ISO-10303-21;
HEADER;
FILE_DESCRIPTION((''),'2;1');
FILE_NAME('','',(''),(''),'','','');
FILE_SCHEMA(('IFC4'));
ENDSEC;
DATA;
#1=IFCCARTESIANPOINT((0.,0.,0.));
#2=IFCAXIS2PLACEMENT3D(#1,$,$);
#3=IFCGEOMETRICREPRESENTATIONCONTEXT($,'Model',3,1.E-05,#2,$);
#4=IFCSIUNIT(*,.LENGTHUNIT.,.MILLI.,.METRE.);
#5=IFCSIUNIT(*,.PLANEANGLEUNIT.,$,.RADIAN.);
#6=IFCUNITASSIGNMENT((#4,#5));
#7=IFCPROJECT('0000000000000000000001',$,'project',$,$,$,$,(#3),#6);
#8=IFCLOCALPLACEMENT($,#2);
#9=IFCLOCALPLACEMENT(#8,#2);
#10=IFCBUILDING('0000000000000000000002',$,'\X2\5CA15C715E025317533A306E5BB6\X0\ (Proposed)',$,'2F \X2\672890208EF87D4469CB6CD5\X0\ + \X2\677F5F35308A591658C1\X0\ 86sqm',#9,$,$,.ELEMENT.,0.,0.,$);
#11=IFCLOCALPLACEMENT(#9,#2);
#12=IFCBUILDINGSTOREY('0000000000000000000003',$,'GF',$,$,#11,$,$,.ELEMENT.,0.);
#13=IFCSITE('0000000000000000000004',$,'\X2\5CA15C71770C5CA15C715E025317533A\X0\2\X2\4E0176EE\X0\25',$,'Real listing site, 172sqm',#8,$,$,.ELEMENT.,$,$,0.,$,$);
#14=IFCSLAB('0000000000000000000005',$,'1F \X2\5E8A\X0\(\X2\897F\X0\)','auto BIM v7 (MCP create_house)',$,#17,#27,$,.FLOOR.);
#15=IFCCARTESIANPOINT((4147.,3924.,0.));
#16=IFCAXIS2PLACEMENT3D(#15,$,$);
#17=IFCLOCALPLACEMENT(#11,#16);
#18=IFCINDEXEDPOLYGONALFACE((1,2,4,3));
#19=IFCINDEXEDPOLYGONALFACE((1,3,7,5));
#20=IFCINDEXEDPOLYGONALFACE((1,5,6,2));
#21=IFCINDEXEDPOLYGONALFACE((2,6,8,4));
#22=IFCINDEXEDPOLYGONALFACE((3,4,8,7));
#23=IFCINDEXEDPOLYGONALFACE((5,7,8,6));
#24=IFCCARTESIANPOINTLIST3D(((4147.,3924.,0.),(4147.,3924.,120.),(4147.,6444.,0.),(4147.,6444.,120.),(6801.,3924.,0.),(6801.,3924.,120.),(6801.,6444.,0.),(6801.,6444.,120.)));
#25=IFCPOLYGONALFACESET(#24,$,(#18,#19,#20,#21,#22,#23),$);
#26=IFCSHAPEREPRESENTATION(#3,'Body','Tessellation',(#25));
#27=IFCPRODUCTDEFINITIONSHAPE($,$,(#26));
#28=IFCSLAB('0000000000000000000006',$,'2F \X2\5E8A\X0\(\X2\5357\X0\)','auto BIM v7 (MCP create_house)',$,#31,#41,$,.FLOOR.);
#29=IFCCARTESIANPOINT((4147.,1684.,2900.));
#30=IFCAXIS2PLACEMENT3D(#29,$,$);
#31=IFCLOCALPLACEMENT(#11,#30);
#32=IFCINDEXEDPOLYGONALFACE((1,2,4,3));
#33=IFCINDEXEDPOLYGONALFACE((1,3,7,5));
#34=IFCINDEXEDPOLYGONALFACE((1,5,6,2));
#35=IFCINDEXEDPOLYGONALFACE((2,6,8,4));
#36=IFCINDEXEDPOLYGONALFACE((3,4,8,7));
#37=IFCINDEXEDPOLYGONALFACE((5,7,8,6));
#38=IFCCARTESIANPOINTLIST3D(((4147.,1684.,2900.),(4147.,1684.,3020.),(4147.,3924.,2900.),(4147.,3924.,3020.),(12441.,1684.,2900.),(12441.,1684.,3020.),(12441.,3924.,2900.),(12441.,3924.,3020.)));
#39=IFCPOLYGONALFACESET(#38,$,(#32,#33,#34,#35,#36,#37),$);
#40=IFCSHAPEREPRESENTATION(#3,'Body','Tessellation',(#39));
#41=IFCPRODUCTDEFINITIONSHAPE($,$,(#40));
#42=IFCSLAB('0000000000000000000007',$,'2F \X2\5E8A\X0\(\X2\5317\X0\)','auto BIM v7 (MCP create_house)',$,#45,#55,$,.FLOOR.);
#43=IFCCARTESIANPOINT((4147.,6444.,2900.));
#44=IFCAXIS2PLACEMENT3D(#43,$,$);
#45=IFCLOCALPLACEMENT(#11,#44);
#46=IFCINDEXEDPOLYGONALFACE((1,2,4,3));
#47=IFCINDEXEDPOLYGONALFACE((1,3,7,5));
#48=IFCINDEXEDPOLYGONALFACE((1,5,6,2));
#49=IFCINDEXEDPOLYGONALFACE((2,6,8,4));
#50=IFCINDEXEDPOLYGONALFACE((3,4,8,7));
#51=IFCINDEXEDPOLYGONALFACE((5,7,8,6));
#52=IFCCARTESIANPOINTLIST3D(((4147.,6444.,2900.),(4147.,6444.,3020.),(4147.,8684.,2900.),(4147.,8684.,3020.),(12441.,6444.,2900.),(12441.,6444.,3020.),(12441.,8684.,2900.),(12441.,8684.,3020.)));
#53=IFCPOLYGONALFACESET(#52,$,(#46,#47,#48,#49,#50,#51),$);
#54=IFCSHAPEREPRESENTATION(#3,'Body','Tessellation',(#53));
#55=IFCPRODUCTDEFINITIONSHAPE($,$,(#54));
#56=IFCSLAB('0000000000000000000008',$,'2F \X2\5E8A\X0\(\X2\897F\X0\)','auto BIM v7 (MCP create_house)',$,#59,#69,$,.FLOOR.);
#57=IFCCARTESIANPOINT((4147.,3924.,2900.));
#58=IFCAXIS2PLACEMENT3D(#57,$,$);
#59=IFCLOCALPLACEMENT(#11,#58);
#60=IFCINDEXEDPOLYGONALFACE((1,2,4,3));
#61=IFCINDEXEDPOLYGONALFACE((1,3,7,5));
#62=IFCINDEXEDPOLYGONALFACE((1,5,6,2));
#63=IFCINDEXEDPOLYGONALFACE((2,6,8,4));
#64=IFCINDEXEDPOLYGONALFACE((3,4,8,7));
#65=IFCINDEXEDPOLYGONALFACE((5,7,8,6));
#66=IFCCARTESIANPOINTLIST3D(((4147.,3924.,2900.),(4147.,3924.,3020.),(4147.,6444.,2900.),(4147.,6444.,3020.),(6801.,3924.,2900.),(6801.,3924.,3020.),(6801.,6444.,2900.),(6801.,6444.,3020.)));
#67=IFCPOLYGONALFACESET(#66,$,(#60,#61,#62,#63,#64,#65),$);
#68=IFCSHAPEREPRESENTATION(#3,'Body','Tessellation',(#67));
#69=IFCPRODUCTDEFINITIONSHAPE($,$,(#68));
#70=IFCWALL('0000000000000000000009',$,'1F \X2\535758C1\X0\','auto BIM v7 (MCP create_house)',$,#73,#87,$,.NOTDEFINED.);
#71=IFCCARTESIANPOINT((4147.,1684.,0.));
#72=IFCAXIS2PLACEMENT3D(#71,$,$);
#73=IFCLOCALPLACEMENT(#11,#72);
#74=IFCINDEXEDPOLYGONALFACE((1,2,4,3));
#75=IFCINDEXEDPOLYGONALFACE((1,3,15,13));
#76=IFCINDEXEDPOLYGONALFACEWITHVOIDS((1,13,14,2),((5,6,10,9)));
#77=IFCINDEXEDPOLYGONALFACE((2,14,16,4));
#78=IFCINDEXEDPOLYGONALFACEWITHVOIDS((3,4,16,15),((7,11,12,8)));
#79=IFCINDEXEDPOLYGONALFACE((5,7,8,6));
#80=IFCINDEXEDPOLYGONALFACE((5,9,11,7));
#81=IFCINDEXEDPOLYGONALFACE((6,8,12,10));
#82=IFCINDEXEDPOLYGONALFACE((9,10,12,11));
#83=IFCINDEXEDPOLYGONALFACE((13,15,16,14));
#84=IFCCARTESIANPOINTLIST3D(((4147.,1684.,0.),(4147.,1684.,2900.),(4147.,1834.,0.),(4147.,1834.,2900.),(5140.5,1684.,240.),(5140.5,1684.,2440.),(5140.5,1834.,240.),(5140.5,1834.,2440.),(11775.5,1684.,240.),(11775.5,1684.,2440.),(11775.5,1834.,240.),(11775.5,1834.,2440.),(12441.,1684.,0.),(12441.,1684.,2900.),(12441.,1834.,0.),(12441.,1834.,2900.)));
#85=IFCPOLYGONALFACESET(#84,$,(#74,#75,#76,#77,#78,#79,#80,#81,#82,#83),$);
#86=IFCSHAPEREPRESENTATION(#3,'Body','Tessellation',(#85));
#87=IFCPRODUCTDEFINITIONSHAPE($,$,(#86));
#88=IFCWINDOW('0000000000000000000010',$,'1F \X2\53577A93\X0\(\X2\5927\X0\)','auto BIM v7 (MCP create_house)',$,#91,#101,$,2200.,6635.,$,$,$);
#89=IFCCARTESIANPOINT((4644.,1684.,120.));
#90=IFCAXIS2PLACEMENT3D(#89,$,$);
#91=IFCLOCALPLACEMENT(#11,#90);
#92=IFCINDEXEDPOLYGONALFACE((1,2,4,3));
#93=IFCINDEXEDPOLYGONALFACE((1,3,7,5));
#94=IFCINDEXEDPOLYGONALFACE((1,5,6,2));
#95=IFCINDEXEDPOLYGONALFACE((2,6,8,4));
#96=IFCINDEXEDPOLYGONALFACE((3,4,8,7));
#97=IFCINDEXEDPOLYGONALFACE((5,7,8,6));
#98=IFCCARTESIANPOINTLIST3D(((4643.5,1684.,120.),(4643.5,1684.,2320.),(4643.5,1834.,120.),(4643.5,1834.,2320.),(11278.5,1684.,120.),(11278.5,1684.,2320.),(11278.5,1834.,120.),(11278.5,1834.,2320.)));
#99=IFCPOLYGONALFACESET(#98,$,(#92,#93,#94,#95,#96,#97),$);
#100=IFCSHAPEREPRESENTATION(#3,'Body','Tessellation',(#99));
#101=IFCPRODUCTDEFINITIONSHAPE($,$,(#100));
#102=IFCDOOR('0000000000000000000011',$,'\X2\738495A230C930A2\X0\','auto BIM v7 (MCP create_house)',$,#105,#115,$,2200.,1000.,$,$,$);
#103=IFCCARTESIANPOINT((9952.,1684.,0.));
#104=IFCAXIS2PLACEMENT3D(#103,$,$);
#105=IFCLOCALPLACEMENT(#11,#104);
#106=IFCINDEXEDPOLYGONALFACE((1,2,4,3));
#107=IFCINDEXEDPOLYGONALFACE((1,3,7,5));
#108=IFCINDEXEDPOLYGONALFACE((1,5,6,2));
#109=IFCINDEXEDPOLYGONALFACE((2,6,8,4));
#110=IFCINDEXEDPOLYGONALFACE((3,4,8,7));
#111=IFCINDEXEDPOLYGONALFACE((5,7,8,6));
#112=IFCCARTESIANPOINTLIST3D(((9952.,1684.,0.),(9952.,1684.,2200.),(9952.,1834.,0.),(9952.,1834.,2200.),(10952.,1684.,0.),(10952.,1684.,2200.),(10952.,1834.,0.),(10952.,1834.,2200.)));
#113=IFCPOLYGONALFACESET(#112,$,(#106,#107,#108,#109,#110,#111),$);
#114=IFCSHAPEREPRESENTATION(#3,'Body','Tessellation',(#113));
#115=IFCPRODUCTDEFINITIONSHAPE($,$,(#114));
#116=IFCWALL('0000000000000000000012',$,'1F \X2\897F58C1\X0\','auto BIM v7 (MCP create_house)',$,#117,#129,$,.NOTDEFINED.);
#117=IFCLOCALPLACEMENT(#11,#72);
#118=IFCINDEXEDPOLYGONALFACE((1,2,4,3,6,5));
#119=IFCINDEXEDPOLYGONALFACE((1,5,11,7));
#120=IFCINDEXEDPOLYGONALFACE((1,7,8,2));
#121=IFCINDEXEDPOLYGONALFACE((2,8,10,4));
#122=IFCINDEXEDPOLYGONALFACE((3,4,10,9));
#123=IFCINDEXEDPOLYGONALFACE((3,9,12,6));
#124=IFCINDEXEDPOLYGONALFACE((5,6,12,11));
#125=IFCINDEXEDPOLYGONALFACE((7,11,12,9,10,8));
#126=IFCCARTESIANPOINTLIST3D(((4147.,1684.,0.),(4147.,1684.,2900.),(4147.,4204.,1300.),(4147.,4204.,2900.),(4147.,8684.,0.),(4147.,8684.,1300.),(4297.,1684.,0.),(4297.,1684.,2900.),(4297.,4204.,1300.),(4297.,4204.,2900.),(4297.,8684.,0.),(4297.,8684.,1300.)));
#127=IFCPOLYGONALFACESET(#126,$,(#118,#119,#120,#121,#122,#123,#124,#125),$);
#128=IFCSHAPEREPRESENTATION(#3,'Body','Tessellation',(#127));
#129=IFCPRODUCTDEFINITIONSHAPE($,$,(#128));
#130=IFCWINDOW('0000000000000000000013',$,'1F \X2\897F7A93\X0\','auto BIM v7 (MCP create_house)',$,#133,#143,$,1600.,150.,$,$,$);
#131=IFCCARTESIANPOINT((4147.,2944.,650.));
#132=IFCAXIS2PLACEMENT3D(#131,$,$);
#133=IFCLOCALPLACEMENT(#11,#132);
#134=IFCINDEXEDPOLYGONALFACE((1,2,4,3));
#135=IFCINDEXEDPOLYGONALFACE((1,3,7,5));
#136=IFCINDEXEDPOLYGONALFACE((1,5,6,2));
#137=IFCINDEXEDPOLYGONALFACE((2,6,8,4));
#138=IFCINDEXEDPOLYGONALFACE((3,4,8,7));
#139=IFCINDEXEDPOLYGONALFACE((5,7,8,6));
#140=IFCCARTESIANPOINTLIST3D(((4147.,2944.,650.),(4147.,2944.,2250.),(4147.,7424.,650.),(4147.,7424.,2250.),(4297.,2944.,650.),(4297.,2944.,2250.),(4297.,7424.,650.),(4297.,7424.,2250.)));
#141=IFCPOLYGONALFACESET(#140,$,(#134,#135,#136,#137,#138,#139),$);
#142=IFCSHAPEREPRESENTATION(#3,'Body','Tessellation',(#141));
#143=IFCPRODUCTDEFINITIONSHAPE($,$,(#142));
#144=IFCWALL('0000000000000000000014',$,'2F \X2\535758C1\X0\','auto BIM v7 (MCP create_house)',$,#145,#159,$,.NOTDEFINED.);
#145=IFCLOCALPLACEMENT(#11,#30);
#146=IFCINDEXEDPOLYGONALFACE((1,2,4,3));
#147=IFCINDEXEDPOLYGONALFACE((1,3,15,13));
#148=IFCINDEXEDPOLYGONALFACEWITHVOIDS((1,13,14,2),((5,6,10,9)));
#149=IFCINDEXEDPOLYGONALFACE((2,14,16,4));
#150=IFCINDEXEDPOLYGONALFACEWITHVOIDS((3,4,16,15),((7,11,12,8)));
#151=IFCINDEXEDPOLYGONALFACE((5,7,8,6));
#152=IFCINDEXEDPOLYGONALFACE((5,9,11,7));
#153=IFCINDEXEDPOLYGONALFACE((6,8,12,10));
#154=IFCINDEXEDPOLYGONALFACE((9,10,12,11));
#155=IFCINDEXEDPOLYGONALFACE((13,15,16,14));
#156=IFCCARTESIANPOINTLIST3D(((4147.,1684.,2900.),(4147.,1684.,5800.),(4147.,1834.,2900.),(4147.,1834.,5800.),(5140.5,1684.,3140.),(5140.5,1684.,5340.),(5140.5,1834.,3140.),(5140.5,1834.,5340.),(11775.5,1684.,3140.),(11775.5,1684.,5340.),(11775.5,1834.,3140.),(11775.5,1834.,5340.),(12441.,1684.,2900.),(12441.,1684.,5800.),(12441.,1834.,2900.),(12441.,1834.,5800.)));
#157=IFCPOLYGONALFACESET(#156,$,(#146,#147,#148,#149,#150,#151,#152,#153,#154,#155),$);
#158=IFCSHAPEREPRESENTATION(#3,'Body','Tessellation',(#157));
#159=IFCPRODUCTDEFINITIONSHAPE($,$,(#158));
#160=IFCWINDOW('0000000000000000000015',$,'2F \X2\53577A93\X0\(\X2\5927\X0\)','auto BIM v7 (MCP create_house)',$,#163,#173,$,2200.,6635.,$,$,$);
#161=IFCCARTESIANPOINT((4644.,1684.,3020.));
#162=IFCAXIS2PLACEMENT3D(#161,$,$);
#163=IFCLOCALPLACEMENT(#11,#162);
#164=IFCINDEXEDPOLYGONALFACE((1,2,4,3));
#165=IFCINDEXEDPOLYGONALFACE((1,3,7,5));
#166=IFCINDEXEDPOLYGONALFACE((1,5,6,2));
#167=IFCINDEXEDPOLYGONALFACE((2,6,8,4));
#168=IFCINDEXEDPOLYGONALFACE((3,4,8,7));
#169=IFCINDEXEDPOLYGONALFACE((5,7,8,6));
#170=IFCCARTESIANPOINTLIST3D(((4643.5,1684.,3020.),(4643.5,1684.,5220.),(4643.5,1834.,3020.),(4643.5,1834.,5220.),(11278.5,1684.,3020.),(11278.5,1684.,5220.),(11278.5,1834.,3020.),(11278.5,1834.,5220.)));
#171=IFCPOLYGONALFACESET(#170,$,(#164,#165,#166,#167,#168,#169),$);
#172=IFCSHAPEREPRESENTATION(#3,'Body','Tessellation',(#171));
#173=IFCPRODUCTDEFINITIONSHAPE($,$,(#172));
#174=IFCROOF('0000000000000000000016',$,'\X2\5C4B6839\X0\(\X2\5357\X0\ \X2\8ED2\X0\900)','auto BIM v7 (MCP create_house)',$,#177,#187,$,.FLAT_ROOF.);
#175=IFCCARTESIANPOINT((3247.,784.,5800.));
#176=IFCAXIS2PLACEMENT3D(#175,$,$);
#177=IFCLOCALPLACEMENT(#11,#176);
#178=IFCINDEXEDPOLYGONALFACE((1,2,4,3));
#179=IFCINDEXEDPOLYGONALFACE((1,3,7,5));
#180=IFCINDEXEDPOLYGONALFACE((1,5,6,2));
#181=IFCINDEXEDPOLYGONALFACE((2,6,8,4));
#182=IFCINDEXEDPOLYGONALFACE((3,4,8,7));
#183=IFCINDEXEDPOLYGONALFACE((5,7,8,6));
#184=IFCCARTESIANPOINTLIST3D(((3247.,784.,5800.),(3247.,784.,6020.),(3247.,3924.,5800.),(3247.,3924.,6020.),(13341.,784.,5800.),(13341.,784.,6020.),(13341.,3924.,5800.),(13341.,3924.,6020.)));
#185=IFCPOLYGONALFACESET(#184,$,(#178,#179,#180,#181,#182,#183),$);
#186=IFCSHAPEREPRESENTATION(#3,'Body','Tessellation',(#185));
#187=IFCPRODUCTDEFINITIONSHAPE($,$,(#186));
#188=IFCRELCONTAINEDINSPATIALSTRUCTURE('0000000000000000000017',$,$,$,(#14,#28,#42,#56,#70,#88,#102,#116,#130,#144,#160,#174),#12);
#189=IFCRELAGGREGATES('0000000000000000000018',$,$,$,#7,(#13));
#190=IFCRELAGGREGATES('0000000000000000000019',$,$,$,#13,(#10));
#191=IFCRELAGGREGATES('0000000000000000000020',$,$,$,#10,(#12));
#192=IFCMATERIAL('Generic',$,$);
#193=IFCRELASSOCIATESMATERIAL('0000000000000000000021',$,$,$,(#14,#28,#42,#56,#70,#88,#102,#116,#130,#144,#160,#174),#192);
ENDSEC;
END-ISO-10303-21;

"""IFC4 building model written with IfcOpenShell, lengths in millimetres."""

from ifc_helpers import new_model, si_unit, frame, frame_2d, origin, place, context, project, spatial, rectangle, extrude, material, element, fill, save


model = new_model("IFC4")

# Units and contexts
model_context = context("Model", 3, precision=1e-05, world=origin())
ifc_project = project(units=[si_unit("LENGTHUNIT", "METRE", prefix="MILLI"), si_unit("PLANEANGLEUNIT", "RADIAN")], contexts=[model_context])

# Site, building, storey
site_placement = place(None, origin())
site = spatial("IfcSite", under=ifc_project, at=site_placement, Name="岡山県岡山市北区2丁目25", ObjectType="Real listing site, 172sqm", CompositionType="ELEMENT", RefElevation=0.0)
building_placement = place(site_placement, origin())
building = spatial("IfcBuilding", under=site, at=building_placement, Name="岡山市北区の家 (Proposed)", ObjectType="2F 木造軸組構法 + 板張り外壁 86sqm", CompositionType="ELEMENT", ElevationOfRefHeight=0.0, ElevationOfTerrain=0.0)
storey_placement = place(building_placement, origin())
storey = spatial("IfcBuildingStorey", under=building, at=storey_placement, Name="GF", CompositionType="ELEMENT", Elevation=0.0)

# Slabs
ifc_material = material(Name="Generic")
slab_1_placement = place(storey_placement, frame((4147.0, 3924.0, 0.0)))
element("IfcSlab", 1, at=slab_1_placement, inside=storey, material=ifc_material, Name="1F 床(西)", Description="auto BIM v7 (MCP create_house)", PredefinedType="FLOOR", context=model_context, shape_type="SweptSolid", body=[
    extrude(rectangle(XDim=2654.0, YDim=2520.0, at=frame_2d((1327.0, 1260.0))), frame((4147.0, 3924.0, 0.0)), (0.0, 0.0, 1.0), 120.0),
])
slab_2_placement = place(storey_placement, frame((4147.0, 1684.0, 2900.0)))
element("IfcSlab", 2, at=slab_2_placement, inside=storey, material=ifc_material, Name="2F 床(南)", Description="auto BIM v7 (MCP create_house)", PredefinedType="FLOOR", context=model_context, shape_type="SweptSolid", body=[
    extrude(rectangle(XDim=8294.0, YDim=2240.0, at=frame_2d((4147.0, 1120.0))), frame((4147.0, 1684.0, 2900.0)), (0.0, 0.0, 1.0), 120.0),
])
slab_3_placement = place(storey_placement, frame((4147.0, 6444.0, 2900.0)))
element("IfcSlab", 3, at=slab_3_placement, inside=storey, material=ifc_material, Name="2F 床(北)", Description="auto BIM v7 (MCP create_house)", PredefinedType="FLOOR", context=model_context, shape_type="SweptSolid", body=[
    extrude(rectangle(XDim=8294.0, YDim=2240.0, at=frame_2d((4147.0, 1120.0))), frame((4147.0, 6444.0, 2900.0)), (0.0, 0.0, 1.0), 120.0),
])
slab_4_placement = place(storey_placement, frame((4147.0, 3924.0, 2900.0)))
element("IfcSlab", 4, at=slab_4_placement, inside=storey, material=ifc_material, Name="2F 床(西)", Description="auto BIM v7 (MCP create_house)", PredefinedType="FLOOR", context=model_context, shape_type="SweptSolid", body=[
    extrude(rectangle(XDim=2654.0, YDim=2520.0, at=frame_2d((1327.0, 1260.0))), frame((4147.0, 3924.0, 2900.0)), (0.0, 0.0, 1.0), 120.0),
])

# Wall, openings, window, door
wall_1_placement = place(storey_placement, frame((4147.0, 1684.0, 0.0)))
wall_1 = element("IfcWall", 5, at=wall_1_placement, inside=storey, material=ifc_material, Name="1F 南壁", Description="auto BIM v7 (MCP create_house)", PredefinedType="NOTDEFINED", context=model_context, shape_type="SweptSolid", body=[
    extrude(rectangle(XDim=8294.0, YDim=150.0, at=frame_2d((4147.0, 75.0))), frame((4147.0, 1684.0, 0.0)), (0.0, 0.0, 1.0), 2900.0),
])
opening_1_placement = place(storey_placement, frame((4644.0, 1684.0, 120.0)))
opening_1 = element("IfcOpeningElement", 6, at=opening_1_placement, cuts=wall_1, PredefinedType="NOTDEFINED", context=model_context, shape_type="SweptSolid", body=[
    extrude(rectangle(XDim=6635.0, YDim=150.0, at=frame_2d((3317.0, 75.0))), frame((4644.0, 1684.0, 120.0)), (0.0, 0.0, 1.0), 2200.0),
])
opening_2_placement = place(storey_placement, frame((9952.0, 1684.0, 0.0)))
opening_2 = element("IfcOpeningElement", 7, at=opening_2_placement, cuts=wall_1, PredefinedType="NOTDEFINED", context=model_context, shape_type="SweptSolid", body=[
    extrude(rectangle(XDim=1000.0, YDim=150.0, at=frame_2d((500.0, 75.0))), frame((9952.0, 1684.0, 0.0)), (0.0, 0.0, 1.0), 2200.0),
])
window_1_placement = place(storey_placement, frame((4644.0, 1684.0, 120.0)))
window_1 = element("IfcWindow", 8, at=window_1_placement, inside=storey, material=ifc_material, Name="1F 南窓(大)", Description="auto BIM v7 (MCP create_house)", OverallHeight=2200.0, OverallWidth=6635.0, context=model_context, shape_type="SweptSolid", body=[
    extrude(rectangle(XDim=6635.0, YDim=150.0, at=frame_2d((3317.0, 75.0))), frame((4644.0, 1684.0, 120.0)), (0.0, 0.0, 1.0), 2200.0),
])
fill(opening_1, window_1)
door_placement = place(storey_placement, frame((9952.0, 1684.0, 0.0)))
door = element("IfcDoor", 9, at=door_placement, inside=storey, material=ifc_material, Name="玄関ドア", Description="auto BIM v7 (MCP create_house)", OverallHeight=2200.0, OverallWidth=1000.0, context=model_context, shape_type="SweptSolid", body=[
    extrude(rectangle(XDim=1000.0, YDim=150.0, at=frame_2d((500.0, 75.0))), frame((9952.0, 1684.0, 0.0)), (0.0, 0.0, 1.0), 2200.0),
])
fill(opening_2, door)

# Walls, openings, windows
wall_2_placement = place(storey_placement, frame((4147.0, 1684.0, 0.0)))
wall_2 = element("IfcWall", 10, at=wall_2_placement, inside=storey, material=ifc_material, Name="1F 西壁", Description="auto BIM v7 (MCP create_house)", PredefinedType="NOTDEFINED", context=model_context, shape_type="SweptSolid", body=[
    extrude(rectangle(XDim=150.0, YDim=7000.0, at=frame_2d((75.0, 3500.0))), frame((4147.0, 1684.0, 0.0)), (0.0, 0.0, 1.0), 2900.0),
])
opening_3_placement = place(storey_placement, frame((4147.0, 2944.0, 650.0)))
opening_3 = element("IfcOpeningElement", 11, at=opening_3_placement, cuts=wall_2, PredefinedType="NOTDEFINED", context=model_context, shape_type="SweptSolid", body=[
    extrude(rectangle(XDim=150.0, YDim=4480.0, at=frame_2d((75.0, 2240.0))), frame((4147.0, 2944.0, 650.0)), (0.0, 0.0, 1.0), 1600.0),
])
window_2_placement = place(storey_placement, frame((4147.0, 2944.0, 650.0)))
window_2 = element("IfcWindow", 12, at=window_2_placement, inside=storey, material=ifc_material, Name="1F 西窓", Description="auto BIM v7 (MCP create_house)", OverallHeight=1600.0, OverallWidth=150.0, context=model_context, shape_type="SweptSolid", body=[
    extrude(rectangle(XDim=150.0, YDim=4480.0, at=frame_2d((75.0, 2240.0))), frame((4147.0, 2944.0, 650.0)), (0.0, 0.0, 1.0), 1600.0),
])
fill(opening_3, window_2)
wall_3_placement = place(storey_placement, frame((4147.0, 1684.0, 2900.0)))
wall_3 = element("IfcWall", 13, at=wall_3_placement, inside=storey, material=ifc_material, Name="2F 南壁", Description="auto BIM v7 (MCP create_house)", PredefinedType="NOTDEFINED", context=model_context, shape_type="SweptSolid", body=[
    extrude(rectangle(XDim=8294.0, YDim=150.0, at=frame_2d((4147.0, 75.0))), frame((4147.0, 1684.0, 2900.0)), (0.0, 0.0, 1.0), 2900.0),
])
opening_4_placement = place(storey_placement, frame((4644.0, 1684.0, 3020.0)))
opening_4 = element("IfcOpeningElement", 14, at=opening_4_placement, cuts=wall_3, PredefinedType="NOTDEFINED", context=model_context, shape_type="SweptSolid", body=[
    extrude(rectangle(XDim=6635.0, YDim=150.0, at=frame_2d((3317.0, 75.0))), frame((4644.0, 1684.0, 3020.0)), (0.0, 0.0, 1.0), 2200.0),
])
window_3_placement = place(storey_placement, frame((4644.0, 1684.0, 3020.0)))
window_3 = element("IfcWindow", 15, at=window_3_placement, inside=storey, material=ifc_material, Name="2F 南窓(大)", Description="auto BIM v7 (MCP create_house)", OverallHeight=2200.0, OverallWidth=6635.0, context=model_context, shape_type="SweptSolid", body=[
    extrude(rectangle(XDim=6635.0, YDim=150.0, at=frame_2d((3317.0, 75.0))), frame((4644.0, 1684.0, 3020.0)), (0.0, 0.0, 1.0), 2200.0),
])
fill(opening_4, window_3)

# Roof
roof_1_placement = place(storey_placement, frame((3247.0, 784.0, 5800.0)))
element("IfcRoof", 16, at=roof_1_placement, inside=storey, material=ifc_material, Name="屋根(南 軒900)", Description="auto BIM v7 (MCP create_house)", PredefinedType="FLAT_ROOF", context=model_context, shape_type="SweptSolid", body=[
    extrude(rectangle(XDim=10094.0, YDim=3140.0, at=frame_2d((5047.0, 1570.0))), frame((3247.0, 784.0, 5800.0)), (0.0, 0.0, 1.0), 220.0),
])

save(model, "model.ifc")
